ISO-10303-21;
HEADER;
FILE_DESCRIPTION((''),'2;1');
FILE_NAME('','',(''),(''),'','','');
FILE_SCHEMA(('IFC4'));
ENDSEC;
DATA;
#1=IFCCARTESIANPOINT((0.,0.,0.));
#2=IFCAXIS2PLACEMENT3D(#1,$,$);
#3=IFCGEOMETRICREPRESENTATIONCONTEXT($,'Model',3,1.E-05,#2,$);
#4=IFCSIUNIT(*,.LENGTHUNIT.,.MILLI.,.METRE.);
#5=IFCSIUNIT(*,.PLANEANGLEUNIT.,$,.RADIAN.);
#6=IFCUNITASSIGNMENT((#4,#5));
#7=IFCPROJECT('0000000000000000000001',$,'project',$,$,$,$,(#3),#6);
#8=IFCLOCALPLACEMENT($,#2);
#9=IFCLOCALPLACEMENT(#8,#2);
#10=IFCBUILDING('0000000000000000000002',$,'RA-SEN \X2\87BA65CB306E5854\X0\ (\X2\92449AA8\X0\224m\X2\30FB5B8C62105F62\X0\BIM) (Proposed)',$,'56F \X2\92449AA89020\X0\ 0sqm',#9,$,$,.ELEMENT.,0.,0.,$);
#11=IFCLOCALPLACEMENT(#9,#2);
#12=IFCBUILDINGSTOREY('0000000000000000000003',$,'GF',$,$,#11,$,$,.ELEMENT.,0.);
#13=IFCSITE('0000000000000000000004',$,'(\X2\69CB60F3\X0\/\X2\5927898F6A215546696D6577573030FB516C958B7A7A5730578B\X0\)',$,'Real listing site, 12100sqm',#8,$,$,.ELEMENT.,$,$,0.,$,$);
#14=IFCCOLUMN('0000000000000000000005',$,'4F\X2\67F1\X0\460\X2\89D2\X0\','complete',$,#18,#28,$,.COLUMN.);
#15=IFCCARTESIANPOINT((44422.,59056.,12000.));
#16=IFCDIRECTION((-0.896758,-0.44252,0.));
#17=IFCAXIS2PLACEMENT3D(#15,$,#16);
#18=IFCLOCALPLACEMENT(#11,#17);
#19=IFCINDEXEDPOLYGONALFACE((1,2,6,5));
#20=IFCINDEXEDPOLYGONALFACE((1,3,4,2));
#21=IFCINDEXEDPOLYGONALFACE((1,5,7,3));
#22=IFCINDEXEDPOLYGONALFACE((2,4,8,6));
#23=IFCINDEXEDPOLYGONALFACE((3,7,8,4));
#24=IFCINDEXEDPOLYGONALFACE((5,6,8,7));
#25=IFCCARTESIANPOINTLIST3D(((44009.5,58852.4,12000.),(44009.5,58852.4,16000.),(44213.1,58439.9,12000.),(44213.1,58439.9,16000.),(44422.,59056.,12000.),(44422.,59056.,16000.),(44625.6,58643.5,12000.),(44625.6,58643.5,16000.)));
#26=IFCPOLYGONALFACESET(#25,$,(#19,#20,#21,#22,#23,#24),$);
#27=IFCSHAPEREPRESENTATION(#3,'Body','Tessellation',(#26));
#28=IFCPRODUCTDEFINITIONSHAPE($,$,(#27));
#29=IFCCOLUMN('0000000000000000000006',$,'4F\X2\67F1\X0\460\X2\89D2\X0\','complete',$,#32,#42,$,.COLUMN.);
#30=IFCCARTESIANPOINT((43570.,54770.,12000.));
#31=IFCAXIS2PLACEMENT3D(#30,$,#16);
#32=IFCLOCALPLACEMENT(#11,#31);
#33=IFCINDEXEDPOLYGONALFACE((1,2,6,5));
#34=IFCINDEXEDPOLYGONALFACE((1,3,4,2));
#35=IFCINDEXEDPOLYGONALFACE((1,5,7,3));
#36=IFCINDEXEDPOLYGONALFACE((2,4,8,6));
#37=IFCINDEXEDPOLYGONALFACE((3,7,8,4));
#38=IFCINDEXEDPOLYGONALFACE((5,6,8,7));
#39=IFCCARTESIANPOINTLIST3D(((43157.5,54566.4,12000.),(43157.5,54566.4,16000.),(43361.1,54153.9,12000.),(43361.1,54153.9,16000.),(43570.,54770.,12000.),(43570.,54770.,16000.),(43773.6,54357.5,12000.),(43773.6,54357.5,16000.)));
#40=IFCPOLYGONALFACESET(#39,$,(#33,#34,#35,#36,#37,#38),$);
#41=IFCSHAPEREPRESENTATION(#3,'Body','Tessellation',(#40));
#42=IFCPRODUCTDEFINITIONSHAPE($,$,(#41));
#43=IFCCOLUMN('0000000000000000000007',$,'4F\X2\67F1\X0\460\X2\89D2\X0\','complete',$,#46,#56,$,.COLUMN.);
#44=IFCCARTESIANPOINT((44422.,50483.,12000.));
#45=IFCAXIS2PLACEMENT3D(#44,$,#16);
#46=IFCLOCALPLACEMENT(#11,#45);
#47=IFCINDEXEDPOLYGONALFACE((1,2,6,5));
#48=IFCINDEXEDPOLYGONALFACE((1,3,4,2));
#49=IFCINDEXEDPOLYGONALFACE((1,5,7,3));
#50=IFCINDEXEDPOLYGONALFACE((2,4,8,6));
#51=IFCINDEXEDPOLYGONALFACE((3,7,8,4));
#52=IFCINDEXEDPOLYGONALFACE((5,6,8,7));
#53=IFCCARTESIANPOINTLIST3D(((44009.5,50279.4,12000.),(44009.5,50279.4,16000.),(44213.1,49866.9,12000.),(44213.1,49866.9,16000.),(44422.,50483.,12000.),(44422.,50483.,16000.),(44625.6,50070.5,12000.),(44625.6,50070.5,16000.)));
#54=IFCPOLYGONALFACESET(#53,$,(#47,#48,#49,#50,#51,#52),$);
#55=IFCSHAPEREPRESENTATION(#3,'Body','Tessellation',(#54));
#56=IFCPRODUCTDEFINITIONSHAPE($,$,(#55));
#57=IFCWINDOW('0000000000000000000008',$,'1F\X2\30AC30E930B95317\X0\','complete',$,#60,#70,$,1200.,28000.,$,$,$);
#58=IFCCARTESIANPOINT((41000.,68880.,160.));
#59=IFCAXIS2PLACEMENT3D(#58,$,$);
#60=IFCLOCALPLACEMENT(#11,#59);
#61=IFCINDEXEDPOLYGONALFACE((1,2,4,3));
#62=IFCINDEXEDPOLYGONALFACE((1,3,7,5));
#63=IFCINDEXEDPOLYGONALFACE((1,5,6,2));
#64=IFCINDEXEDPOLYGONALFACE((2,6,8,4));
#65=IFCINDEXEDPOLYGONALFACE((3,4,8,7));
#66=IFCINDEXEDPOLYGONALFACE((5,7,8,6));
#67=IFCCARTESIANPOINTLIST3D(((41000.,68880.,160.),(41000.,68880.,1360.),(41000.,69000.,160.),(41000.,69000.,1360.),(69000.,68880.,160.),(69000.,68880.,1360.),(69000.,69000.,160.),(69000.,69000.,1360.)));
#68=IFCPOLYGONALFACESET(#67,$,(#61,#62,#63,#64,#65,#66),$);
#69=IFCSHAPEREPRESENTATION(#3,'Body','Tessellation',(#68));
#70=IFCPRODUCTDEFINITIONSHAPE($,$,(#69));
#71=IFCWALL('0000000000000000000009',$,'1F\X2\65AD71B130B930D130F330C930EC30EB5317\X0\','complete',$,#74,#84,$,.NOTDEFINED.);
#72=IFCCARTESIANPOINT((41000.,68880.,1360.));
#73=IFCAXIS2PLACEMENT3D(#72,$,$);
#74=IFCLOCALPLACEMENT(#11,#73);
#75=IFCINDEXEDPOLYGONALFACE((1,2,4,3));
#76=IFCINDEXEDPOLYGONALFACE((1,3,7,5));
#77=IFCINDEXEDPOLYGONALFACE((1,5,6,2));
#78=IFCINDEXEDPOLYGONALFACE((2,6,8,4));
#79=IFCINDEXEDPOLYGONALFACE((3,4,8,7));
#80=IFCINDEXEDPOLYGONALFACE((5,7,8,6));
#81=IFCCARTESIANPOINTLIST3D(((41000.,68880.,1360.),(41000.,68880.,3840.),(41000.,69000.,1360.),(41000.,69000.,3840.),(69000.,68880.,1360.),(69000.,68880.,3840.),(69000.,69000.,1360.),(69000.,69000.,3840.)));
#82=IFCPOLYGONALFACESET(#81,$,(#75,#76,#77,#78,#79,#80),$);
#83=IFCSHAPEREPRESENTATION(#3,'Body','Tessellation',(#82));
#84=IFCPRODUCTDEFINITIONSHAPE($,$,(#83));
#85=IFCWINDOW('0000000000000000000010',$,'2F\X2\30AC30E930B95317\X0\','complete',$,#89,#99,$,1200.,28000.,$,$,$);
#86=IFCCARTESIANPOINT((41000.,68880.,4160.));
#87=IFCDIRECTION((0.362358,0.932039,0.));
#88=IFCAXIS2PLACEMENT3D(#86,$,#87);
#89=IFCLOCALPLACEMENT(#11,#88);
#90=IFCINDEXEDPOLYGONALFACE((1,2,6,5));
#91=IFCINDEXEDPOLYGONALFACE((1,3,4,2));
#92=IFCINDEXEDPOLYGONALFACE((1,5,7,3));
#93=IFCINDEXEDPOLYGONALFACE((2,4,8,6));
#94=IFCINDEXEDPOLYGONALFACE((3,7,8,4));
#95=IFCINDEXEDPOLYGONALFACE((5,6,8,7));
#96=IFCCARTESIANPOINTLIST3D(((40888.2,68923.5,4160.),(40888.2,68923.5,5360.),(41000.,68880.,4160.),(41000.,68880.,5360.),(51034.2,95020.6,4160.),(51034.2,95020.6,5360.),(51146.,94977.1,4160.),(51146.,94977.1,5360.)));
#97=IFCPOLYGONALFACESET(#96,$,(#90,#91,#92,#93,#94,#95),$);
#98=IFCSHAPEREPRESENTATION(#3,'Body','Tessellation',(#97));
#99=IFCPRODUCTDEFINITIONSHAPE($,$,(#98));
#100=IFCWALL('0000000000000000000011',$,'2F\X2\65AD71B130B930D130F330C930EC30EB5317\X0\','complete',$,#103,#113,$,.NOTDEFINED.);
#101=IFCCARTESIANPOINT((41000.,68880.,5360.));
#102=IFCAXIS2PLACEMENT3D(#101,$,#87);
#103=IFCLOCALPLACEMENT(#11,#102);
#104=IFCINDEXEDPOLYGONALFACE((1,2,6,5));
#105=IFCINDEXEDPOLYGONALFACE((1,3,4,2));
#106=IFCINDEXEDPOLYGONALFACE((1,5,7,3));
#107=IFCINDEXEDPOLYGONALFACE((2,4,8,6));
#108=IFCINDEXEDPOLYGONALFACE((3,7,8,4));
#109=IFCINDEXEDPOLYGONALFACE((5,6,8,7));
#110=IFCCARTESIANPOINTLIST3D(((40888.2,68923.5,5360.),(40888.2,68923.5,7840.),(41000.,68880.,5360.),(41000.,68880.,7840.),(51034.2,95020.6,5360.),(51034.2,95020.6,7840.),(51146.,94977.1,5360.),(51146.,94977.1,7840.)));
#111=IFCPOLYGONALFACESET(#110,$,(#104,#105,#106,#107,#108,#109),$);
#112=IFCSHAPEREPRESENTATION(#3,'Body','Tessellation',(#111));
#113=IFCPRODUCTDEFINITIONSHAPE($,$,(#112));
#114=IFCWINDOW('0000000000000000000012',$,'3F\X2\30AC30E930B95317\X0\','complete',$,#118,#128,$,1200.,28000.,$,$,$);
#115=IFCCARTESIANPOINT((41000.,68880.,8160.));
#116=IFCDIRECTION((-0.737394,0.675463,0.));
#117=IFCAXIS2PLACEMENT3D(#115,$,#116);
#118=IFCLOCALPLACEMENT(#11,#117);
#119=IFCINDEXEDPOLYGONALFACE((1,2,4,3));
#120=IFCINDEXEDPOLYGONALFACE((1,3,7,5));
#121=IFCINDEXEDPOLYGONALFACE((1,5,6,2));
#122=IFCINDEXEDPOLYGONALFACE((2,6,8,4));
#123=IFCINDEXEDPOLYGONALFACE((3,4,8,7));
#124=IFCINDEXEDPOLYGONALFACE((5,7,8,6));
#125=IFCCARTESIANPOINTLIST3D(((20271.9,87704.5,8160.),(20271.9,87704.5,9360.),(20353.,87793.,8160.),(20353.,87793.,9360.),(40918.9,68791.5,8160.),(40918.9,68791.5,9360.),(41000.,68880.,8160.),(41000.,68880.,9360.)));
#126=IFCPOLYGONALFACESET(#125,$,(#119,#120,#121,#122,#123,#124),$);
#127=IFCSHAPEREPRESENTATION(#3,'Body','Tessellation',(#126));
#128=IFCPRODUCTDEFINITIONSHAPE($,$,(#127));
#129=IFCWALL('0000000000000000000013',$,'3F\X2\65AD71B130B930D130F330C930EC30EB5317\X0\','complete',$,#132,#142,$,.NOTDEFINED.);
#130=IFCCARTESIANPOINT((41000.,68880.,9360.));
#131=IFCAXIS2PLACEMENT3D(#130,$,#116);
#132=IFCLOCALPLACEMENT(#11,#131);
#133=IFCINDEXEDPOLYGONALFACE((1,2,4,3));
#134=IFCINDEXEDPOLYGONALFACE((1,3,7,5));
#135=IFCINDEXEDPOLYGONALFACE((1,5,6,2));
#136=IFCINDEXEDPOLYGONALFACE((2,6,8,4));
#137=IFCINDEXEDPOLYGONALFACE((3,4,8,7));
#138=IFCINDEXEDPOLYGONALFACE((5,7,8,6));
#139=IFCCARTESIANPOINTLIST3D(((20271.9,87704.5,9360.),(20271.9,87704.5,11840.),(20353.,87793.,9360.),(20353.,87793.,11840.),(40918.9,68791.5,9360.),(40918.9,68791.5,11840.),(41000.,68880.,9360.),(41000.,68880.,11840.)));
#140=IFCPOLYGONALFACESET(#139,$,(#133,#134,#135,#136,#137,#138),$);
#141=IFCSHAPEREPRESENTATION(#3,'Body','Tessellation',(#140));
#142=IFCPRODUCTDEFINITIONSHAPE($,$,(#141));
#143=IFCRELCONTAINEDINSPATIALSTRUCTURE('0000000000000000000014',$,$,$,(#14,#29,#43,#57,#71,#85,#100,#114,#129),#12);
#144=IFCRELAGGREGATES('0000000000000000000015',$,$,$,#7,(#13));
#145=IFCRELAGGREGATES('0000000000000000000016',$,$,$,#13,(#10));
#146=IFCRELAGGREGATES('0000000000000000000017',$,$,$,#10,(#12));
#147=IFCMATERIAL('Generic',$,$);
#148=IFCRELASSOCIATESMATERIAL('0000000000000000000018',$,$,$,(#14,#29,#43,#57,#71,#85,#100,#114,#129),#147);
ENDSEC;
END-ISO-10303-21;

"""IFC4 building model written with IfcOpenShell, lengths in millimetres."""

from ifc_helpers import new_model, si_unit, frame, frame_2d, origin, place, context, project, spatial, rectangle, extrude, material, element, save


model = new_model("IFC4")

# Units and contexts
model_context = context("Model", 3, precision=1e-05, world=origin())
ifc_project = project(units=[si_unit("LENGTHUNIT", "METRE", prefix="MILLI"), si_unit("PLANEANGLEUNIT", "RADIAN")], contexts=[model_context])

# Site, building, storey
site_placement = place(None, origin())
site = spatial("IfcSite", under=ifc_project, at=site_placement, Name="(構想/大規模商業敷地・公開空地型)", ObjectType="Real listing site, 12100sqm", CompositionType="ELEMENT", RefElevation=0.0)
building_placement = place(site_placement, origin())
building = spatial("IfcBuilding", under=site, at=building_placement, Name="RA-SEN 螺旋の塔 (鉄骨224m・完成形BIM) (Proposed)", ObjectType="56F 鉄骨造 0sqm", CompositionType="ELEMENT", ElevationOfRefHeight=0.0, ElevationOfTerrain=0.0)
storey_placement = place(building_placement, origin())
storey = spatial("IfcBuildingStorey", under=building, at=storey_placement, Name="GF", CompositionType="ELEMENT", Elevation=0.0)

# Columns
ifc_material = material(Name="Generic")
column_1_placement = place(storey_placement, frame((44422.0, 59056.0, 12000.0), x_axis=(-0.896758, -0.44252, 0.0)))
element("IfcColumn", 1, at=column_1_placement, inside=storey, material=ifc_material, Name="4F柱460角", Description="complete", PredefinedType="COLUMN", context=model_context, shape_type="SweptSolid", body=[
    extrude(rectangle(XDim=460.0, YDim=460.0, at=frame_2d((230.0, 230.0))), frame((44422.0, 59056.0, 12000.0), x_axis=(-0.896758, -0.44252, 0.0)), (0.0, 0.0, 1.0), 4000.0),
])
column_2_placement = place(storey_placement, frame((43570.0, 54770.0, 12000.0), x_axis=(-0.896758, -0.44252, 0.0)))
element("IfcColumn", 2, at=column_2_placement, inside=storey, material=ifc_material, Name="4F柱460角", Description="complete", PredefinedType="COLUMN", context=model_context, shape_type="SweptSolid", body=[
    extrude(rectangle(XDim=460.0, YDim=460.0, at=frame_2d((230.0, 230.0))), frame((43570.0, 54770.0, 12000.0), x_axis=(-0.896758, -0.44252, 0.0)), (0.0, 0.0, 1.0), 4000.0),
])
column_3_placement = place(storey_placement, frame((44422.0, 50483.0, 12000.0), x_axis=(-0.896758, -0.44252, 0.0)))
element("IfcColumn", 3, at=column_3_placement, inside=storey, material=ifc_material, Name="4F柱460角", Description="complete", PredefinedType="COLUMN", context=model_context, shape_type="SweptSolid", body=[
    extrude(rectangle(XDim=460.0, YDim=460.0, at=frame_2d((230.0, 230.0))), frame((44422.0, 50483.0, 12000.0), x_axis=(-0.896758, -0.44252, 0.0)), (0.0, 0.0, 1.0), 4000.0),
])

# Window
window_1_placement = place(storey_placement, frame((41000.0, 68880.0, 160.0)))
element("IfcWindow", 4, at=window_1_placement, inside=storey, material=ifc_material, Name="1Fガラス北", Description="complete", OverallHeight=1200.0, OverallWidth=28000.0, context=model_context, shape_type="SweptSolid", body=[
    extrude(rectangle(XDim=28000.0, YDim=120.0, at=frame_2d((14000.0, 60.0))), frame((41000.0, 68880.0, 160.0)), (0.0, 0.0, 1.0), 1200.0),
])

# Wall
wall_1_placement = place(storey_placement, frame((41000.0, 68880.0, 1360.0)))
element("IfcWall", 5, at=wall_1_placement, inside=storey, material=ifc_material, Name="1F断熱スパンドレル北", Description="complete", PredefinedType="NOTDEFINED", context=model_context, shape_type="SweptSolid", body=[
    extrude(rectangle(XDim=28000.0, YDim=120.0, at=frame_2d((14000.0, 60.0))), frame((41000.0, 68880.0, 1360.0)), (0.0, 0.0, 1.0), 2480.0),
])

# Window
window_2_placement = place(storey_placement, frame((41000.0, 68880.0, 4160.0), x_axis=(0.362358, 0.932039, 0.0)))
element("IfcWindow", 6, at=window_2_placement, inside=storey, material=ifc_material, Name="2Fガラス北", Description="complete", OverallHeight=1200.0, OverallWidth=28000.0, context=model_context, shape_type="SweptSolid", body=[
    extrude(rectangle(XDim=28000.0, YDim=120.0, at=frame_2d((14000.0, 60.0))), frame((41000.0, 68880.0, 4160.0), x_axis=(0.362358, 0.932039, 0.0)), (0.0, 0.0, 1.0), 1200.0),
])

# Wall
wall_2_placement = place(storey_placement, frame((41000.0, 68880.0, 5360.0), x_axis=(0.362358, 0.932039, 0.0)))
element("IfcWall", 7, at=wall_2_placement, inside=storey, material=ifc_material, Name="2F断熱スパンドレル北", Description="complete", PredefinedType="NOTDEFINED", context=model_context, shape_type="SweptSolid", body=[
    extrude(rectangle(XDim=28000.0, YDim=120.0, at=frame_2d((14000.0, 60.0))), frame((41000.0, 68880.0, 5360.0), x_axis=(0.362358, 0.932039, 0.0)), (0.0, 0.0, 1.0), 2480.0),
])

# Window
window_3_placement = place(storey_placement, frame((41000.0, 68880.0, 8160.0), x_axis=(-0.737394, 0.675463, 0.0)))
element("IfcWindow", 8, at=window_3_placement, inside=storey, material=ifc_material, Name="3Fガラス北", Description="complete", OverallHeight=1200.0, OverallWidth=28000.0, context=model_context, shape_type="SweptSolid", body=[
    extrude(rectangle(XDim=28000.0, YDim=120.0, at=frame_2d((14000.0, 60.0))), frame((41000.0, 68880.0, 8160.0), x_axis=(-0.737394, 0.675463, 0.0)), (0.0, 0.0, 1.0), 1200.0),
])

# Wall
wall_3_placement = place(storey_placement, frame((41000.0, 68880.0, 9360.0), x_axis=(-0.737394, 0.675463, 0.0)))
element("IfcWall", 9, at=wall_3_placement, inside=storey, material=ifc_material, Name="3F断熱スパンドレル北", Description="complete", PredefinedType="NOTDEFINED", context=model_context, shape_type="SweptSolid", body=[
    extrude(rectangle(XDim=28000.0, YDim=120.0, at=frame_2d((14000.0, 60.0))), frame((41000.0, 68880.0, 9360.0), x_axis=(-0.737394, 0.675463, 0.0)), (0.0, 0.0, 1.0), 2480.0),
])

save(model, "model.ifc")
